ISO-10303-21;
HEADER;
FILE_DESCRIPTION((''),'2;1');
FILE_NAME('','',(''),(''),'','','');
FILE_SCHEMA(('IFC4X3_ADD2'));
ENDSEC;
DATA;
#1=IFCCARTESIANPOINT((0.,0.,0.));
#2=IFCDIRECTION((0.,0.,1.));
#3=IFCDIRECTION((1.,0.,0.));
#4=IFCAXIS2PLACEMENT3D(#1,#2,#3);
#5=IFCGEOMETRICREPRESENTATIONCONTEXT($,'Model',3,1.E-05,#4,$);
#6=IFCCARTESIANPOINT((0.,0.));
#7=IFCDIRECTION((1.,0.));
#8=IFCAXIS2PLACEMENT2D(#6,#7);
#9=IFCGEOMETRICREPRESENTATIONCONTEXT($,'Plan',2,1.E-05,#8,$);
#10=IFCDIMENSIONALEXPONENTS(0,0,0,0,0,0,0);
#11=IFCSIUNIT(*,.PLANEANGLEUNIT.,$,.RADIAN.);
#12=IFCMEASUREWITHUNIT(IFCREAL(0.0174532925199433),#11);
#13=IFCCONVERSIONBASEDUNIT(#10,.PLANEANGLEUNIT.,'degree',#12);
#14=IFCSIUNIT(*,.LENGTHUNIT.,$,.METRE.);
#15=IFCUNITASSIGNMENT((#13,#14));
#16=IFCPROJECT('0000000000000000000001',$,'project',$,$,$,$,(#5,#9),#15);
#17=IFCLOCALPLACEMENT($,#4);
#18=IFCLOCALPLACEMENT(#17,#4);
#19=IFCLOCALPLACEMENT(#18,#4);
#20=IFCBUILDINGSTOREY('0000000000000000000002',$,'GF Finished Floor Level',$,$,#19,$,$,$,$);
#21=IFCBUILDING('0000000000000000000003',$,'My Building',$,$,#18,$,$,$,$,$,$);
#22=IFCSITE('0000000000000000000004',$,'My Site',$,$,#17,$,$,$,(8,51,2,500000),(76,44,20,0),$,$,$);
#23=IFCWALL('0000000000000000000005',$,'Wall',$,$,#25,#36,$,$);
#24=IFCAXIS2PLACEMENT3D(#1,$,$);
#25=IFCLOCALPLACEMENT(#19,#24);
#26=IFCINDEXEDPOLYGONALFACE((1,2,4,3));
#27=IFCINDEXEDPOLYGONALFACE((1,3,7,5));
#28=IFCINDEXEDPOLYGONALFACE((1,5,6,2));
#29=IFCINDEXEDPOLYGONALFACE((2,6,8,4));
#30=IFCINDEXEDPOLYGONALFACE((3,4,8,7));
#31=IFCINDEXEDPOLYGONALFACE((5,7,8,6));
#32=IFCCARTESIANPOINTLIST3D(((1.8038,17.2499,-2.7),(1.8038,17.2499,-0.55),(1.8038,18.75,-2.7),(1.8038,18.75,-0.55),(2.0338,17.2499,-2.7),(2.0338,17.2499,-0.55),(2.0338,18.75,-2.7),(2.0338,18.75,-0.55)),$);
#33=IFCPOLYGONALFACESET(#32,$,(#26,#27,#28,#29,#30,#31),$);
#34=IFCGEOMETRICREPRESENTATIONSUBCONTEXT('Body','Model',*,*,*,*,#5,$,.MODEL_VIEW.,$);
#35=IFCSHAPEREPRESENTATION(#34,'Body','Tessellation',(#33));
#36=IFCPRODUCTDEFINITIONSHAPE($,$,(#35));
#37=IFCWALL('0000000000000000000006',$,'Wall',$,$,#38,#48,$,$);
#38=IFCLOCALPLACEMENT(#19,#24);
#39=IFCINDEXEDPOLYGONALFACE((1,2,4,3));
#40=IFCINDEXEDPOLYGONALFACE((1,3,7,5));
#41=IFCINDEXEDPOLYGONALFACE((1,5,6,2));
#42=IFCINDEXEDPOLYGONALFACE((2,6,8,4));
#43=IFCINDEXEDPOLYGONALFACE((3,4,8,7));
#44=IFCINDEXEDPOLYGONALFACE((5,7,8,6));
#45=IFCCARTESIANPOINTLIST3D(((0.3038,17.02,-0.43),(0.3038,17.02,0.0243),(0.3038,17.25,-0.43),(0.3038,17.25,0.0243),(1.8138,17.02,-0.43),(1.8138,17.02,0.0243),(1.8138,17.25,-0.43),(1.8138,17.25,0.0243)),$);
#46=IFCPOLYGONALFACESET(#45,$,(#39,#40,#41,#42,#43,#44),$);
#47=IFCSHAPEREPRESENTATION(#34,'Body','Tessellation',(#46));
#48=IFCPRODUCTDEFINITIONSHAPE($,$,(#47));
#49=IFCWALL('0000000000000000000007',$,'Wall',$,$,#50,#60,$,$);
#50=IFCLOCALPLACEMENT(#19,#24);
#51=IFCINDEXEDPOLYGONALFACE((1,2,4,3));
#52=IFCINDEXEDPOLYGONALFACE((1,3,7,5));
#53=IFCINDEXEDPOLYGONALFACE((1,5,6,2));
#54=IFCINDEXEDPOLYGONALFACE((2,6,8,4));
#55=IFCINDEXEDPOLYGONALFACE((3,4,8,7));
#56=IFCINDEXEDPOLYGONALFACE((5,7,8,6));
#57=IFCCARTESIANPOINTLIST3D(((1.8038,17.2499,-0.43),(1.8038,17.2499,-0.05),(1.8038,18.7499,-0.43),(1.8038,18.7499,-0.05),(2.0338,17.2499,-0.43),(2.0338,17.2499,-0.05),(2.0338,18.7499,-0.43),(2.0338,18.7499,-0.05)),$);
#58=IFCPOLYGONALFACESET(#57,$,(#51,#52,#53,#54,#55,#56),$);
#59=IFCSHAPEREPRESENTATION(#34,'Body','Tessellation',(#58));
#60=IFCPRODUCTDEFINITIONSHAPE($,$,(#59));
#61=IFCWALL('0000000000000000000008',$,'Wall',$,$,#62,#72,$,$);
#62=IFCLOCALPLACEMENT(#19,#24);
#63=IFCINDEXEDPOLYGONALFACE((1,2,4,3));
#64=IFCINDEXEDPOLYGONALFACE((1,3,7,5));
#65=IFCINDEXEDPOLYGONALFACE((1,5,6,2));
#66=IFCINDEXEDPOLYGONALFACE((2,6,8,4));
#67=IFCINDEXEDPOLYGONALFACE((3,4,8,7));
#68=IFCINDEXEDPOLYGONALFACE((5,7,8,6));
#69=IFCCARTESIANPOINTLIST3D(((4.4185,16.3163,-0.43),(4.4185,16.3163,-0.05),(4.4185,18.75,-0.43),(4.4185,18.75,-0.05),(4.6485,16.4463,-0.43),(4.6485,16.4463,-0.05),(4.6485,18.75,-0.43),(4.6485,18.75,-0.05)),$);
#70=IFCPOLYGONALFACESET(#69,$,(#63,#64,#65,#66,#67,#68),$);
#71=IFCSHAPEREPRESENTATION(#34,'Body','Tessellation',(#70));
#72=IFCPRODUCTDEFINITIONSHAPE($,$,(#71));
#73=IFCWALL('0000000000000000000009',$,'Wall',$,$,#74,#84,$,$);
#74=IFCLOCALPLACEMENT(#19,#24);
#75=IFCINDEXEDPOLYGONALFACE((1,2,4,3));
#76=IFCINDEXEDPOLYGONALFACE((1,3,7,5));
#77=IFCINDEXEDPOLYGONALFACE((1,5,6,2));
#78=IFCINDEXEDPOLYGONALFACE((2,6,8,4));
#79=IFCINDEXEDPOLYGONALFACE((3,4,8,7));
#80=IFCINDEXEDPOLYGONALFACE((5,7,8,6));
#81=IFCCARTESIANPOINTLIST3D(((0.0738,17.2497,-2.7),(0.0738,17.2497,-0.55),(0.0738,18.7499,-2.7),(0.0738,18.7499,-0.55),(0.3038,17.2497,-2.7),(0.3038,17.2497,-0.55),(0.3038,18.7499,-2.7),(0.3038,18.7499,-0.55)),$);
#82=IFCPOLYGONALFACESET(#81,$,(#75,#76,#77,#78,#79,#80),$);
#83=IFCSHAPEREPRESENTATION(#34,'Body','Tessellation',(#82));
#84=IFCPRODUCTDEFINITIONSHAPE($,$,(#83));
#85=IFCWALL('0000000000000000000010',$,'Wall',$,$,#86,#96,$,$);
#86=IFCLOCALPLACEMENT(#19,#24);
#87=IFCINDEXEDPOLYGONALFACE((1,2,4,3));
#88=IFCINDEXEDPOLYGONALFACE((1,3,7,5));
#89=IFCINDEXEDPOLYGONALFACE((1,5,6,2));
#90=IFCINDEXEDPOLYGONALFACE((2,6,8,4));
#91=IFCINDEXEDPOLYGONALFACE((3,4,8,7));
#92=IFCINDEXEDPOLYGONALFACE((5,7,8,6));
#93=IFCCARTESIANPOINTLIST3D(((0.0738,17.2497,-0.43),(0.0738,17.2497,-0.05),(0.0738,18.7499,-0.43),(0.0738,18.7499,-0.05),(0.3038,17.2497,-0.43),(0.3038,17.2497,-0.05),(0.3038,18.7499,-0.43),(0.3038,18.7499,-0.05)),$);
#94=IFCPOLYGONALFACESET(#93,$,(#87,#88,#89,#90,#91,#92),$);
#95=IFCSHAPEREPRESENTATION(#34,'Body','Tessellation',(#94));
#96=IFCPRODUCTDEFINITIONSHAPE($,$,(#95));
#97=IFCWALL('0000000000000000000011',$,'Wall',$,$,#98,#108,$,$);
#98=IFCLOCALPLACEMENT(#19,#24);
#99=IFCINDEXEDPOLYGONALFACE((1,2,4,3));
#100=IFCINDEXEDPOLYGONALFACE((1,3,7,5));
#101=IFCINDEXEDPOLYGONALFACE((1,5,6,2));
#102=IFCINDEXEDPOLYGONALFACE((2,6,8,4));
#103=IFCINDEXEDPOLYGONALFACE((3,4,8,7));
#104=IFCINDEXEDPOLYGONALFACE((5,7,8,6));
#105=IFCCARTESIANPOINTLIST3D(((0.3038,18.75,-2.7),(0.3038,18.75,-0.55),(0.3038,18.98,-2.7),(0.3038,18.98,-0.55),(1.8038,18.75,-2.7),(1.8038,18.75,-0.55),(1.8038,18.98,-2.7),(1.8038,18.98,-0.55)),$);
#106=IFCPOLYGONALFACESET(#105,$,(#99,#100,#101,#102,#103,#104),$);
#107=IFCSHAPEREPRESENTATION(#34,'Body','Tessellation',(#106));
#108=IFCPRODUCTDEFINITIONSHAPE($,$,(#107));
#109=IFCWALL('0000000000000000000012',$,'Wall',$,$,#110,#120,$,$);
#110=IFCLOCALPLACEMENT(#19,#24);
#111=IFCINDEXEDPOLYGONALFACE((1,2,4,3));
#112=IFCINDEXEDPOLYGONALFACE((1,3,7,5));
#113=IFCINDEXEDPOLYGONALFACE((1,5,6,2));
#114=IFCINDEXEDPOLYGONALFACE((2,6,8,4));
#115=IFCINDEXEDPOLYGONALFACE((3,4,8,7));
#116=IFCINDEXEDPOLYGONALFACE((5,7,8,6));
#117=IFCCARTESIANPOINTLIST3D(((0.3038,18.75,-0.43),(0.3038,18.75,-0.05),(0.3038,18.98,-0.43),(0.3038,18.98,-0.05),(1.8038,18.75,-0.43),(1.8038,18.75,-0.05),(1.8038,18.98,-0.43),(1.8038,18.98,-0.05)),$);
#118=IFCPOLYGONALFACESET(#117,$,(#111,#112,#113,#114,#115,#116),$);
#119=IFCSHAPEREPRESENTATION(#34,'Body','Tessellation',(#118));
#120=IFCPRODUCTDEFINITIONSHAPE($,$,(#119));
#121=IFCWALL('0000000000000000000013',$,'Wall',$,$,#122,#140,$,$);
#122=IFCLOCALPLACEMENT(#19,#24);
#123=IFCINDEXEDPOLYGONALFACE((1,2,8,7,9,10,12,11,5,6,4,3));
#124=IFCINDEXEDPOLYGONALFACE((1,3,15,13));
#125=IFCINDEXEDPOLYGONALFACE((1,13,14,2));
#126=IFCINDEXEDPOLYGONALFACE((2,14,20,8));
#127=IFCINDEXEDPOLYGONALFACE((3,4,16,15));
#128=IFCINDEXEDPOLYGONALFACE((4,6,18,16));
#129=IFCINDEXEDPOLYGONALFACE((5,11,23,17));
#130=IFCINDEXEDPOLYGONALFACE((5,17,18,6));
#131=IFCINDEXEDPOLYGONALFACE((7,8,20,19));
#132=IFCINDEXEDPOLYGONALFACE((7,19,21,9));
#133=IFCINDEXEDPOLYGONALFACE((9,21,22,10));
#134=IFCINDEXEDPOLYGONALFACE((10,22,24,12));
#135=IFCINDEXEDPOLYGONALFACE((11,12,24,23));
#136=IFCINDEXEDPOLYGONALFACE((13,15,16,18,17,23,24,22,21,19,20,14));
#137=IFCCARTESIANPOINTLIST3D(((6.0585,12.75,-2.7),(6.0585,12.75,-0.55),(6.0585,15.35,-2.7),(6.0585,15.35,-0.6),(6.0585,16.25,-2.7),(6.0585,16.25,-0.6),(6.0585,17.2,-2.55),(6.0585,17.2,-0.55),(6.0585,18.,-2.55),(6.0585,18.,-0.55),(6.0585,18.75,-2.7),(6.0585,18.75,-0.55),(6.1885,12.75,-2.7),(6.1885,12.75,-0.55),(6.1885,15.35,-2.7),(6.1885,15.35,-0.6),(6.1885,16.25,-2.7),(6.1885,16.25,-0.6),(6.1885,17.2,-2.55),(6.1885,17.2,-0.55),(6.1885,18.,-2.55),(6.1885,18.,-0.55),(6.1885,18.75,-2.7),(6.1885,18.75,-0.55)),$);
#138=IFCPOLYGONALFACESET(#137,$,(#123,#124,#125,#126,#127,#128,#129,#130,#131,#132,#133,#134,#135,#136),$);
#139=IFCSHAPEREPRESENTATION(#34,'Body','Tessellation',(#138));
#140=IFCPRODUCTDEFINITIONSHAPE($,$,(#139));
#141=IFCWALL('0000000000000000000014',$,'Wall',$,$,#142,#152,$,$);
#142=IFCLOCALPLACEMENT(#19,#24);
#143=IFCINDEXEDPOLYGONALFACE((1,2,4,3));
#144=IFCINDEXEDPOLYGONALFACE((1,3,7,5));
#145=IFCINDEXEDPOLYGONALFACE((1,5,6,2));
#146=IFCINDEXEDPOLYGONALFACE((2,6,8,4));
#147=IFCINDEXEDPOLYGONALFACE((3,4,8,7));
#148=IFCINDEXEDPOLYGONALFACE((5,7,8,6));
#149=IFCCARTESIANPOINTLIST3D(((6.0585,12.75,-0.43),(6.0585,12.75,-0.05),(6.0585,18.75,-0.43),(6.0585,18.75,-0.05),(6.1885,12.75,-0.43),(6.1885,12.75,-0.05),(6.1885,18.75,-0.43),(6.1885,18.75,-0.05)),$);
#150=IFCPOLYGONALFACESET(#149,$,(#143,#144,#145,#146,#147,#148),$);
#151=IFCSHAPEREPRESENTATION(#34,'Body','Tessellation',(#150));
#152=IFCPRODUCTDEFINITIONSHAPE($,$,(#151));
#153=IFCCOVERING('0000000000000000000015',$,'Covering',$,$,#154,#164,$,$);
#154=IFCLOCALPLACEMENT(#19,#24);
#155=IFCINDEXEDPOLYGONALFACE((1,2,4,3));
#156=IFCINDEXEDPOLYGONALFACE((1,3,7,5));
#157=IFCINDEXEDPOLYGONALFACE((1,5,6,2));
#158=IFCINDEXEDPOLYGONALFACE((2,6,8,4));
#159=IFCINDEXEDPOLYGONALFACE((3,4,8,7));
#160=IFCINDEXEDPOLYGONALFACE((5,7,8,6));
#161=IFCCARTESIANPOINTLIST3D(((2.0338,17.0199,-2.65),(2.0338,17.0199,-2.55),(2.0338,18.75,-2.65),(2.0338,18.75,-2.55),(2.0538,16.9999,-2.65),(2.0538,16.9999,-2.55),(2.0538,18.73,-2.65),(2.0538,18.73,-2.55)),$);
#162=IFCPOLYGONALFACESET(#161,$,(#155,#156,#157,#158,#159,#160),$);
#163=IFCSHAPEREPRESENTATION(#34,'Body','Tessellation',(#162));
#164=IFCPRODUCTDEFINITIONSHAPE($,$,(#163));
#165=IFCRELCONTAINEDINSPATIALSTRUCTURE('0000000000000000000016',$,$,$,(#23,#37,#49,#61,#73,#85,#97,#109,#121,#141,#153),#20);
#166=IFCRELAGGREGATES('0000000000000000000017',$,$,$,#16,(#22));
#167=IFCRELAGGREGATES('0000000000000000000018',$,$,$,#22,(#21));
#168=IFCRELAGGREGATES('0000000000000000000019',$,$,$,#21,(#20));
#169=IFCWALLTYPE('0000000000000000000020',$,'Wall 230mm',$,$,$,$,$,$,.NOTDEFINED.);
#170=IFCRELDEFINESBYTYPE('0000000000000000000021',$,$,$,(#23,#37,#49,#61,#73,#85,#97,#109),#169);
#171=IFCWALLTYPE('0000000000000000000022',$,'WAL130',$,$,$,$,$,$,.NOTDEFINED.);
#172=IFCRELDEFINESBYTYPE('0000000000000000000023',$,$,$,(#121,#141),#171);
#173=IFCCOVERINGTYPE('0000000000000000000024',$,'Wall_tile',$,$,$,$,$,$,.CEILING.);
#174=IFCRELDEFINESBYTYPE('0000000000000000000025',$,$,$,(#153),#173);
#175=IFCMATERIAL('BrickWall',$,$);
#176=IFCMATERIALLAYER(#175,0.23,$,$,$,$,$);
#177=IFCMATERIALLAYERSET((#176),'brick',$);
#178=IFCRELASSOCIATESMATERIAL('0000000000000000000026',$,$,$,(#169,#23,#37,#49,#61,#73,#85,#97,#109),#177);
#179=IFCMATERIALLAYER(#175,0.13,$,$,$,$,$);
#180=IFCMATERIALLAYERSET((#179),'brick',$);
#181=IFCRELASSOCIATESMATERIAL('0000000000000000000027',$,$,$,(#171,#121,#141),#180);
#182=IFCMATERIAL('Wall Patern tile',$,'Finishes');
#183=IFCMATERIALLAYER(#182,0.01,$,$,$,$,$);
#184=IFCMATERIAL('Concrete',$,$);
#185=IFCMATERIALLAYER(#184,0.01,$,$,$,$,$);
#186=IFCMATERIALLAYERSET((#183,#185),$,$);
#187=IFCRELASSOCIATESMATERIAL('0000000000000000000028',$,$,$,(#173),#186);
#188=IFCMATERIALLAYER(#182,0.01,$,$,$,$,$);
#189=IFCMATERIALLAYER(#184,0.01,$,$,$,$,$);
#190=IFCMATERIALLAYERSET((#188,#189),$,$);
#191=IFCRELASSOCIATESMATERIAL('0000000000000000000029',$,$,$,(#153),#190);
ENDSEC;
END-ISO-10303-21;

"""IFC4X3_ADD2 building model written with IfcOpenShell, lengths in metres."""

from ifc_helpers import new_model, entity, si_unit, converted_unit, frame, origin_with_axes, origin_2d_with_axis, place, context, subcontext, project, spatial, line, indexed_curve, outline, extrude, source, transform, mapped, material, layer, layer_set, layer_usage, type_object, element, save


model = new_model("IFC4X3_ADD2")

# Units and contexts
model_context = context("Model", 3, precision=1e-05, world=origin_with_axes())
plan_context = context("Plan", 2, precision=1e-05, world=origin_2d_with_axis())
body_context_1 = subcontext(model_context, "Body", "Model", "MODEL_VIEW")
ifc_project = project(units=[converted_unit("PLANEANGLEUNIT", "degree", entity("IfcReal", 0.0174532925199433), si_unit("PLANEANGLEUNIT", "RADIAN"), dimensions=[0, 0, 0, 0, 0, 0, 0]), si_unit("LENGTHUNIT", "METRE")], contexts=[model_context, plan_context])

# Site, building, storey
site_placement = place(None, origin_with_axes())
site = spatial("IfcSite", under=ifc_project, at=site_placement, Name="My Site", RefLatitude=(8, 51, 2, 500000), RefLongitude=(76, 44, 20, 0))
building_placement = place(site_placement, origin_with_axes())
building = spatial("IfcBuilding", under=site, at=building_placement, Name="My Building")
storey_placement = place(building_placement, origin_with_axes())
storey = spatial("IfcBuildingStorey", under=building, at=storey_placement, Name="GF Finished Floor Level")

# Shared definitions
ifc_material_1 = material(Name="BrickWall")
ifc_layer_1 = layer(ifc_material_1, 0.23)
ifc_layer_set_1 = layer_set([ifc_layer_1], Name="brick")
wall_type_1 = type_object("IfcWallType", Name="Wall 230mm", PredefinedType="NOTDEFINED", material=ifc_layer_set_1)

# Walls
ifc_layer_usage_1 = layer_usage(ifc_layer_set_1, "AXIS2", "POSITIVE", 0.0)
wall_1_placement = place(storey_placement, frame((2.0338, 17.2499, -2.7), z_axis=(0.0, 0.0, 1.0), x_axis=(0.000001, 1.0, 0.0)))
element("IfcWall", 1, at=wall_1_placement, inside=storey, type_object=wall_type_1, material=ifc_layer_usage_1, Name="Wall", context=body_context_1, shape_type="SweptSolid", body=[
    extrude(outline(indexed_curve([(0.0, 0.0), (0.0, 0.23), (1.5001, 0.23), (1.5001, 0.0)], segments=[line(1, 2, 3, 4, 1)])), origin_with_axes(), (0.0, 0.0, 1.0), 2.15),
])
ifc_layer_usage_2 = layer_usage(ifc_layer_set_1, "AXIS2", "POSITIVE", 0.0)
wall_2_placement = place(storey_placement, frame((1.8138, 17.25, -0.43), z_axis=(0.0, 0.0, 1.0), x_axis=(-1.0, 0.0, 0.0)))
element("IfcWall", 2, at=wall_2_placement, inside=storey, type_object=wall_type_1, material=ifc_layer_usage_2, Name="Wall", context=body_context_1, shape_type="SweptSolid", body=[
    extrude(outline(indexed_curve([(0.0, 0.0), (0.0, 0.23), (1.51, 0.23), (1.51, 0.0)], segments=[line(1, 2, 3, 4, 1)])), origin_with_axes(), (0.0, 0.0, 1.0), 0.4543),
])
ifc_layer_usage_3 = layer_usage(ifc_layer_set_1, "AXIS2", "POSITIVE", 0.0)
wall_3_placement = place(storey_placement, frame((2.0338, 17.2499, -0.43), z_axis=(0.0, 0.0, 1.0), x_axis=(0.000001, 1.0, 0.0)))
element("IfcWall", 3, at=wall_3_placement, inside=storey, type_object=wall_type_1, material=ifc_layer_usage_3, Name="Wall", context=body_context_1, shape_type="SweptSolid", body=[
    extrude(outline(indexed_curve([(0.0, 0.0), (0.0, 0.23), (1.5, 0.23), (1.5, 0.0)], segments=[line(1, 2, 3, 4, 1)])), origin_with_axes(), (0.0, 0.0, 1.0), 0.38),
])
ifc_layer_usage_4 = layer_usage(ifc_layer_set_1, "AXIS2", "POSITIVE", 0.0)
wall_4_placement = place(storey_placement, frame((4.4185, 18.75, -0.43), z_axis=(0.0, 0.0, 1.0), x_axis=(0.0, -1.0, 0.0)))
element("IfcWall", 4, at=wall_4_placement, inside=storey, type_object=wall_type_1, material=ifc_layer_usage_4, Name="Wall", context=body_context_1, shape_type="SweptSolid", body=[
    extrude(outline(indexed_curve([(0.0, 0.0), (0.0, 0.23), (2.3037, 0.23), (2.4337, 0.0)], segments=[line(1, 2, 3, 4, 1)])), origin_with_axes(), (0.0, 0.0, 1.0), 0.38),
])
ifc_layer_usage_5 = layer_usage(ifc_layer_set_1, "AXIS2", "POSITIVE", 0.0)
wall_5_placement = place(storey_placement, frame((0.3038, 17.2497, -2.7), z_axis=(0.0, 0.0, 1.0), x_axis=(0.0, 1.0, 0.0)))
element("IfcWall", 5, at=wall_5_placement, inside=storey, type_object=wall_type_1, material=ifc_layer_usage_5, Name="Wall", context=body_context_1, shape_type="SweptSolid", body=[
    extrude(outline(indexed_curve([(0.0, 0.0), (0.0, 0.23), (1.5002, 0.23), (1.5002, 0.0)], segments=[line(1, 2, 3, 4, 1)])), origin_with_axes(), (0.0, 0.0, 1.0), 2.15),
])
ifc_layer_usage_6 = layer_usage(ifc_layer_set_1, "AXIS2", "POSITIVE", 0.0)
wall_6_placement = place(storey_placement, frame((0.3038, 17.2497, -0.43), z_axis=(0.0, 0.0, 1.0), x_axis=(0.0, 1.0, 0.0)))
element("IfcWall", 6, at=wall_6_placement, inside=storey, type_object=wall_type_1, material=ifc_layer_usage_6, Name="Wall", context=body_context_1, shape_type="SweptSolid", body=[
    extrude(outline(indexed_curve([(0.0, 0.0), (0.0, 0.23), (1.5002, 0.23), (1.5002, 0.0)], segments=[line(1, 2, 3, 4, 1)])), origin_with_axes(), (0.0, 0.0, 1.0), 0.38),
])
ifc_layer_usage_7 = layer_usage(ifc_layer_set_1, "AXIS2", "POSITIVE", 0.0)
wall_7_placement = place(storey_placement, frame((1.8038, 18.98, -2.7), z_axis=(0.0, 0.0, 1.0), x_axis=(-1.0, 0.0, 0.0)))
element("IfcWall", 7, at=wall_7_placement, inside=storey, type_object=wall_type_1, material=ifc_layer_usage_7, Name="Wall", context=body_context_1, shape_type="SweptSolid", body=[
    extrude(outline(indexed_curve([(0.0, 0.0), (0.0, 0.23), (1.5, 0.23), (1.5, 0.0)], segments=[line(1, 2, 3, 4, 1)])), origin_with_axes(), (0.0, 0.0, 1.0), 2.15),
])
ifc_layer_usage_8 = layer_usage(ifc_layer_set_1, "AXIS2", "POSITIVE", 0.0)
wall_8_placement = place(storey_placement, frame((1.8038, 18.98, -0.43), z_axis=(0.0, 0.0, 1.0), x_axis=(-1.0, 0.0, 0.0)))
element("IfcWall", 8, at=wall_8_placement, inside=storey, type_object=wall_type_1, material=ifc_layer_usage_8, Name="Wall", context=body_context_1, shape_type="SweptSolid", body=[
    extrude(outline(indexed_curve([(0.0, 0.0), (0.0, 0.23), (1.5, 0.23), (1.5, 0.0)], segments=[line(1, 2, 3, 4, 1)])), origin_with_axes(), (0.0, 0.0, 1.0), 0.38),
])

# Wall, openings
ifc_layer_2 = layer(ifc_material_1, 0.13)
ifc_layer_set_2 = layer_set([ifc_layer_2], Name="brick")
ifc_layer_usage_9 = layer_usage(ifc_layer_set_2, "AXIS2", "POSITIVE", 0.0)
wall_type_2 = type_object("IfcWallType", Name="WAL130", PredefinedType="NOTDEFINED", material=ifc_layer_set_2)
wall_9_placement = place(storey_placement, frame((6.0585, 18.75, -2.7), z_axis=(0.0, 0.0, 1.0), x_axis=(0.0, -1.0, 0.0)))
wall_9 = element("IfcWall", 9, at=wall_9_placement, inside=storey, type_object=wall_type_2, material=ifc_layer_usage_9, Name="Wall", context=body_context_1, shape_type="SweptSolid", body=[
    extrude(outline(indexed_curve([(0.0, 0.0), (0.0, 0.13), (6.0, 0.13), (6.0, 0.0)], segments=[line(1, 2, 3, 4, 1)])), origin_with_axes(), (0.0, 0.0, 1.0), 2.15),
])
shared_shape_1 = source(origin_with_axes(), body_context_1, "Body", "SweptSolid", [
    extrude(outline(indexed_curve([(0.0, 2.1), (0.9, 2.1), (0.9, 0.0), (0.0, 0.0), (0.0, 2.1)])), frame((0.0, -0.6, 0.0), z_axis=(0.0, -1.0, 0.0), x_axis=(1.0, 0.0, 0.0)), (0.0, 0.0, -1.0), 1.2),
])
opening_1_placement = place(wall_9_placement, frame((2.5, 0.0, 0.0), z_axis=(0.0, 0.0, 1.0), x_axis=(1.0, 0.0, 0.0)))
element("IfcOpeningElement", 10, at=opening_1_placement, cuts=wall_9, PredefinedType="OPENING", context=body_context_1, shape_type="MappedRepresentation", body=[
    mapped(shared_shape_1, transform((0.0, 0.0, 0.0), x_axis=(1.0, 0.0, 0.0), y_axis=(0.0, 1.0, 0.0), z_axis=(0.0, 0.0, 1.0), scale=1.0)),
])
shared_shape_2 = source(origin_with_axes(), body_context_1, "Body", "SweptSolid", [
    extrude(outline(indexed_curve([(0.0, 0.0), (0.8, 0.0), (0.8, 2.1), (0.0, 2.1)], segments=[line(1, 2, 3, 4, 1)])), frame((0.0, -0.6, 0.0), z_axis=(0.0, -1.0, 0.0), x_axis=(1.0, 0.0, 0.0)), (0.0, 0.0, -1.0), 1.2),
])
opening_2_placement = place(wall_9_placement, frame((1.55, 0.13, 0.15), z_axis=(0.0, 0.0, 1.0), x_axis=(-1.0, 0.0, 0.0)))
element("IfcOpeningElement", 11, at=opening_2_placement, cuts=wall_9, PredefinedType="OPENING", context=body_context_1, shape_type="MappedRepresentation", body=[
    mapped(shared_shape_2, transform((0.0, 0.0, 0.0), x_axis=(1.0, 0.0, 0.0), y_axis=(0.0, 1.0, 0.0), z_axis=(0.0, 0.0, 1.0), scale=1.0)),
])

# Wall
ifc_layer_usage_10 = layer_usage(ifc_layer_set_2, "AXIS2", "POSITIVE", 0.0)
wall_10_placement = place(storey_placement, frame((6.0585, 18.75, -0.43), z_axis=(0.0, 0.0, 1.0), x_axis=(0.0, -1.0, 0.0)))
element("IfcWall", 12, at=wall_10_placement, inside=storey, type_object=wall_type_2, material=ifc_layer_usage_10, Name="Wall", context=body_context_1, shape_type="SweptSolid", body=[
    extrude(outline(indexed_curve([(0.0, 0.0), (0.0, 0.13), (6.0, 0.13), (6.0, 0.0)], segments=[line(1, 2, 3, 4, 1)])), origin_with_axes(), (0.0, 0.0, 1.0), 0.38),
])

# Covering
ifc_material_2 = material(Name="Wall Patern tile", Category="Finishes")
ifc_layer_3 = layer(ifc_material_2, 0.01)
ifc_material_3 = material(Name="Concrete")
ifc_layer_4 = layer(ifc_material_3, 0.01)
ifc_layer_set_3 = layer_set([ifc_layer_3, ifc_layer_4])
ifc_layer_usage_11 = layer_usage(ifc_layer_set_3, "AXIS2", "POSITIVE", 0.0)
ifc_layer_5 = layer(ifc_material_2, 0.01)
ifc_layer_6 = layer(ifc_material_3, 0.01)
ifc_layer_set_4 = layer_set([ifc_layer_5, ifc_layer_6])
covering_type_1 = type_object("IfcCoveringType", Name="Wall_tile", PredefinedType="CEILING", material=ifc_layer_set_4)
covering_1_placement = place(storey_placement, frame((2.0538, 16.9999, -2.65), z_axis=(0.0, 0.0, 1.0), x_axis=(0.0, 1.0, 0.0)))
element("IfcCovering", 13, at=covering_1_placement, inside=storey, type_object=covering_type_1, material=ifc_layer_usage_11, Name="Covering", context=body_context_1, shape_type="SweptSolid", body=[
    extrude(outline(indexed_curve([(0.0, 0.0), (0.02, 0.02), (1.7501, 0.02), (1.7301, 0.0)], segments=[line(1, 2, 3, 4, 1)])), origin_with_axes(), (0.0, 0.0, 1.0), 0.1),
])

save(model, "model.ifc")
